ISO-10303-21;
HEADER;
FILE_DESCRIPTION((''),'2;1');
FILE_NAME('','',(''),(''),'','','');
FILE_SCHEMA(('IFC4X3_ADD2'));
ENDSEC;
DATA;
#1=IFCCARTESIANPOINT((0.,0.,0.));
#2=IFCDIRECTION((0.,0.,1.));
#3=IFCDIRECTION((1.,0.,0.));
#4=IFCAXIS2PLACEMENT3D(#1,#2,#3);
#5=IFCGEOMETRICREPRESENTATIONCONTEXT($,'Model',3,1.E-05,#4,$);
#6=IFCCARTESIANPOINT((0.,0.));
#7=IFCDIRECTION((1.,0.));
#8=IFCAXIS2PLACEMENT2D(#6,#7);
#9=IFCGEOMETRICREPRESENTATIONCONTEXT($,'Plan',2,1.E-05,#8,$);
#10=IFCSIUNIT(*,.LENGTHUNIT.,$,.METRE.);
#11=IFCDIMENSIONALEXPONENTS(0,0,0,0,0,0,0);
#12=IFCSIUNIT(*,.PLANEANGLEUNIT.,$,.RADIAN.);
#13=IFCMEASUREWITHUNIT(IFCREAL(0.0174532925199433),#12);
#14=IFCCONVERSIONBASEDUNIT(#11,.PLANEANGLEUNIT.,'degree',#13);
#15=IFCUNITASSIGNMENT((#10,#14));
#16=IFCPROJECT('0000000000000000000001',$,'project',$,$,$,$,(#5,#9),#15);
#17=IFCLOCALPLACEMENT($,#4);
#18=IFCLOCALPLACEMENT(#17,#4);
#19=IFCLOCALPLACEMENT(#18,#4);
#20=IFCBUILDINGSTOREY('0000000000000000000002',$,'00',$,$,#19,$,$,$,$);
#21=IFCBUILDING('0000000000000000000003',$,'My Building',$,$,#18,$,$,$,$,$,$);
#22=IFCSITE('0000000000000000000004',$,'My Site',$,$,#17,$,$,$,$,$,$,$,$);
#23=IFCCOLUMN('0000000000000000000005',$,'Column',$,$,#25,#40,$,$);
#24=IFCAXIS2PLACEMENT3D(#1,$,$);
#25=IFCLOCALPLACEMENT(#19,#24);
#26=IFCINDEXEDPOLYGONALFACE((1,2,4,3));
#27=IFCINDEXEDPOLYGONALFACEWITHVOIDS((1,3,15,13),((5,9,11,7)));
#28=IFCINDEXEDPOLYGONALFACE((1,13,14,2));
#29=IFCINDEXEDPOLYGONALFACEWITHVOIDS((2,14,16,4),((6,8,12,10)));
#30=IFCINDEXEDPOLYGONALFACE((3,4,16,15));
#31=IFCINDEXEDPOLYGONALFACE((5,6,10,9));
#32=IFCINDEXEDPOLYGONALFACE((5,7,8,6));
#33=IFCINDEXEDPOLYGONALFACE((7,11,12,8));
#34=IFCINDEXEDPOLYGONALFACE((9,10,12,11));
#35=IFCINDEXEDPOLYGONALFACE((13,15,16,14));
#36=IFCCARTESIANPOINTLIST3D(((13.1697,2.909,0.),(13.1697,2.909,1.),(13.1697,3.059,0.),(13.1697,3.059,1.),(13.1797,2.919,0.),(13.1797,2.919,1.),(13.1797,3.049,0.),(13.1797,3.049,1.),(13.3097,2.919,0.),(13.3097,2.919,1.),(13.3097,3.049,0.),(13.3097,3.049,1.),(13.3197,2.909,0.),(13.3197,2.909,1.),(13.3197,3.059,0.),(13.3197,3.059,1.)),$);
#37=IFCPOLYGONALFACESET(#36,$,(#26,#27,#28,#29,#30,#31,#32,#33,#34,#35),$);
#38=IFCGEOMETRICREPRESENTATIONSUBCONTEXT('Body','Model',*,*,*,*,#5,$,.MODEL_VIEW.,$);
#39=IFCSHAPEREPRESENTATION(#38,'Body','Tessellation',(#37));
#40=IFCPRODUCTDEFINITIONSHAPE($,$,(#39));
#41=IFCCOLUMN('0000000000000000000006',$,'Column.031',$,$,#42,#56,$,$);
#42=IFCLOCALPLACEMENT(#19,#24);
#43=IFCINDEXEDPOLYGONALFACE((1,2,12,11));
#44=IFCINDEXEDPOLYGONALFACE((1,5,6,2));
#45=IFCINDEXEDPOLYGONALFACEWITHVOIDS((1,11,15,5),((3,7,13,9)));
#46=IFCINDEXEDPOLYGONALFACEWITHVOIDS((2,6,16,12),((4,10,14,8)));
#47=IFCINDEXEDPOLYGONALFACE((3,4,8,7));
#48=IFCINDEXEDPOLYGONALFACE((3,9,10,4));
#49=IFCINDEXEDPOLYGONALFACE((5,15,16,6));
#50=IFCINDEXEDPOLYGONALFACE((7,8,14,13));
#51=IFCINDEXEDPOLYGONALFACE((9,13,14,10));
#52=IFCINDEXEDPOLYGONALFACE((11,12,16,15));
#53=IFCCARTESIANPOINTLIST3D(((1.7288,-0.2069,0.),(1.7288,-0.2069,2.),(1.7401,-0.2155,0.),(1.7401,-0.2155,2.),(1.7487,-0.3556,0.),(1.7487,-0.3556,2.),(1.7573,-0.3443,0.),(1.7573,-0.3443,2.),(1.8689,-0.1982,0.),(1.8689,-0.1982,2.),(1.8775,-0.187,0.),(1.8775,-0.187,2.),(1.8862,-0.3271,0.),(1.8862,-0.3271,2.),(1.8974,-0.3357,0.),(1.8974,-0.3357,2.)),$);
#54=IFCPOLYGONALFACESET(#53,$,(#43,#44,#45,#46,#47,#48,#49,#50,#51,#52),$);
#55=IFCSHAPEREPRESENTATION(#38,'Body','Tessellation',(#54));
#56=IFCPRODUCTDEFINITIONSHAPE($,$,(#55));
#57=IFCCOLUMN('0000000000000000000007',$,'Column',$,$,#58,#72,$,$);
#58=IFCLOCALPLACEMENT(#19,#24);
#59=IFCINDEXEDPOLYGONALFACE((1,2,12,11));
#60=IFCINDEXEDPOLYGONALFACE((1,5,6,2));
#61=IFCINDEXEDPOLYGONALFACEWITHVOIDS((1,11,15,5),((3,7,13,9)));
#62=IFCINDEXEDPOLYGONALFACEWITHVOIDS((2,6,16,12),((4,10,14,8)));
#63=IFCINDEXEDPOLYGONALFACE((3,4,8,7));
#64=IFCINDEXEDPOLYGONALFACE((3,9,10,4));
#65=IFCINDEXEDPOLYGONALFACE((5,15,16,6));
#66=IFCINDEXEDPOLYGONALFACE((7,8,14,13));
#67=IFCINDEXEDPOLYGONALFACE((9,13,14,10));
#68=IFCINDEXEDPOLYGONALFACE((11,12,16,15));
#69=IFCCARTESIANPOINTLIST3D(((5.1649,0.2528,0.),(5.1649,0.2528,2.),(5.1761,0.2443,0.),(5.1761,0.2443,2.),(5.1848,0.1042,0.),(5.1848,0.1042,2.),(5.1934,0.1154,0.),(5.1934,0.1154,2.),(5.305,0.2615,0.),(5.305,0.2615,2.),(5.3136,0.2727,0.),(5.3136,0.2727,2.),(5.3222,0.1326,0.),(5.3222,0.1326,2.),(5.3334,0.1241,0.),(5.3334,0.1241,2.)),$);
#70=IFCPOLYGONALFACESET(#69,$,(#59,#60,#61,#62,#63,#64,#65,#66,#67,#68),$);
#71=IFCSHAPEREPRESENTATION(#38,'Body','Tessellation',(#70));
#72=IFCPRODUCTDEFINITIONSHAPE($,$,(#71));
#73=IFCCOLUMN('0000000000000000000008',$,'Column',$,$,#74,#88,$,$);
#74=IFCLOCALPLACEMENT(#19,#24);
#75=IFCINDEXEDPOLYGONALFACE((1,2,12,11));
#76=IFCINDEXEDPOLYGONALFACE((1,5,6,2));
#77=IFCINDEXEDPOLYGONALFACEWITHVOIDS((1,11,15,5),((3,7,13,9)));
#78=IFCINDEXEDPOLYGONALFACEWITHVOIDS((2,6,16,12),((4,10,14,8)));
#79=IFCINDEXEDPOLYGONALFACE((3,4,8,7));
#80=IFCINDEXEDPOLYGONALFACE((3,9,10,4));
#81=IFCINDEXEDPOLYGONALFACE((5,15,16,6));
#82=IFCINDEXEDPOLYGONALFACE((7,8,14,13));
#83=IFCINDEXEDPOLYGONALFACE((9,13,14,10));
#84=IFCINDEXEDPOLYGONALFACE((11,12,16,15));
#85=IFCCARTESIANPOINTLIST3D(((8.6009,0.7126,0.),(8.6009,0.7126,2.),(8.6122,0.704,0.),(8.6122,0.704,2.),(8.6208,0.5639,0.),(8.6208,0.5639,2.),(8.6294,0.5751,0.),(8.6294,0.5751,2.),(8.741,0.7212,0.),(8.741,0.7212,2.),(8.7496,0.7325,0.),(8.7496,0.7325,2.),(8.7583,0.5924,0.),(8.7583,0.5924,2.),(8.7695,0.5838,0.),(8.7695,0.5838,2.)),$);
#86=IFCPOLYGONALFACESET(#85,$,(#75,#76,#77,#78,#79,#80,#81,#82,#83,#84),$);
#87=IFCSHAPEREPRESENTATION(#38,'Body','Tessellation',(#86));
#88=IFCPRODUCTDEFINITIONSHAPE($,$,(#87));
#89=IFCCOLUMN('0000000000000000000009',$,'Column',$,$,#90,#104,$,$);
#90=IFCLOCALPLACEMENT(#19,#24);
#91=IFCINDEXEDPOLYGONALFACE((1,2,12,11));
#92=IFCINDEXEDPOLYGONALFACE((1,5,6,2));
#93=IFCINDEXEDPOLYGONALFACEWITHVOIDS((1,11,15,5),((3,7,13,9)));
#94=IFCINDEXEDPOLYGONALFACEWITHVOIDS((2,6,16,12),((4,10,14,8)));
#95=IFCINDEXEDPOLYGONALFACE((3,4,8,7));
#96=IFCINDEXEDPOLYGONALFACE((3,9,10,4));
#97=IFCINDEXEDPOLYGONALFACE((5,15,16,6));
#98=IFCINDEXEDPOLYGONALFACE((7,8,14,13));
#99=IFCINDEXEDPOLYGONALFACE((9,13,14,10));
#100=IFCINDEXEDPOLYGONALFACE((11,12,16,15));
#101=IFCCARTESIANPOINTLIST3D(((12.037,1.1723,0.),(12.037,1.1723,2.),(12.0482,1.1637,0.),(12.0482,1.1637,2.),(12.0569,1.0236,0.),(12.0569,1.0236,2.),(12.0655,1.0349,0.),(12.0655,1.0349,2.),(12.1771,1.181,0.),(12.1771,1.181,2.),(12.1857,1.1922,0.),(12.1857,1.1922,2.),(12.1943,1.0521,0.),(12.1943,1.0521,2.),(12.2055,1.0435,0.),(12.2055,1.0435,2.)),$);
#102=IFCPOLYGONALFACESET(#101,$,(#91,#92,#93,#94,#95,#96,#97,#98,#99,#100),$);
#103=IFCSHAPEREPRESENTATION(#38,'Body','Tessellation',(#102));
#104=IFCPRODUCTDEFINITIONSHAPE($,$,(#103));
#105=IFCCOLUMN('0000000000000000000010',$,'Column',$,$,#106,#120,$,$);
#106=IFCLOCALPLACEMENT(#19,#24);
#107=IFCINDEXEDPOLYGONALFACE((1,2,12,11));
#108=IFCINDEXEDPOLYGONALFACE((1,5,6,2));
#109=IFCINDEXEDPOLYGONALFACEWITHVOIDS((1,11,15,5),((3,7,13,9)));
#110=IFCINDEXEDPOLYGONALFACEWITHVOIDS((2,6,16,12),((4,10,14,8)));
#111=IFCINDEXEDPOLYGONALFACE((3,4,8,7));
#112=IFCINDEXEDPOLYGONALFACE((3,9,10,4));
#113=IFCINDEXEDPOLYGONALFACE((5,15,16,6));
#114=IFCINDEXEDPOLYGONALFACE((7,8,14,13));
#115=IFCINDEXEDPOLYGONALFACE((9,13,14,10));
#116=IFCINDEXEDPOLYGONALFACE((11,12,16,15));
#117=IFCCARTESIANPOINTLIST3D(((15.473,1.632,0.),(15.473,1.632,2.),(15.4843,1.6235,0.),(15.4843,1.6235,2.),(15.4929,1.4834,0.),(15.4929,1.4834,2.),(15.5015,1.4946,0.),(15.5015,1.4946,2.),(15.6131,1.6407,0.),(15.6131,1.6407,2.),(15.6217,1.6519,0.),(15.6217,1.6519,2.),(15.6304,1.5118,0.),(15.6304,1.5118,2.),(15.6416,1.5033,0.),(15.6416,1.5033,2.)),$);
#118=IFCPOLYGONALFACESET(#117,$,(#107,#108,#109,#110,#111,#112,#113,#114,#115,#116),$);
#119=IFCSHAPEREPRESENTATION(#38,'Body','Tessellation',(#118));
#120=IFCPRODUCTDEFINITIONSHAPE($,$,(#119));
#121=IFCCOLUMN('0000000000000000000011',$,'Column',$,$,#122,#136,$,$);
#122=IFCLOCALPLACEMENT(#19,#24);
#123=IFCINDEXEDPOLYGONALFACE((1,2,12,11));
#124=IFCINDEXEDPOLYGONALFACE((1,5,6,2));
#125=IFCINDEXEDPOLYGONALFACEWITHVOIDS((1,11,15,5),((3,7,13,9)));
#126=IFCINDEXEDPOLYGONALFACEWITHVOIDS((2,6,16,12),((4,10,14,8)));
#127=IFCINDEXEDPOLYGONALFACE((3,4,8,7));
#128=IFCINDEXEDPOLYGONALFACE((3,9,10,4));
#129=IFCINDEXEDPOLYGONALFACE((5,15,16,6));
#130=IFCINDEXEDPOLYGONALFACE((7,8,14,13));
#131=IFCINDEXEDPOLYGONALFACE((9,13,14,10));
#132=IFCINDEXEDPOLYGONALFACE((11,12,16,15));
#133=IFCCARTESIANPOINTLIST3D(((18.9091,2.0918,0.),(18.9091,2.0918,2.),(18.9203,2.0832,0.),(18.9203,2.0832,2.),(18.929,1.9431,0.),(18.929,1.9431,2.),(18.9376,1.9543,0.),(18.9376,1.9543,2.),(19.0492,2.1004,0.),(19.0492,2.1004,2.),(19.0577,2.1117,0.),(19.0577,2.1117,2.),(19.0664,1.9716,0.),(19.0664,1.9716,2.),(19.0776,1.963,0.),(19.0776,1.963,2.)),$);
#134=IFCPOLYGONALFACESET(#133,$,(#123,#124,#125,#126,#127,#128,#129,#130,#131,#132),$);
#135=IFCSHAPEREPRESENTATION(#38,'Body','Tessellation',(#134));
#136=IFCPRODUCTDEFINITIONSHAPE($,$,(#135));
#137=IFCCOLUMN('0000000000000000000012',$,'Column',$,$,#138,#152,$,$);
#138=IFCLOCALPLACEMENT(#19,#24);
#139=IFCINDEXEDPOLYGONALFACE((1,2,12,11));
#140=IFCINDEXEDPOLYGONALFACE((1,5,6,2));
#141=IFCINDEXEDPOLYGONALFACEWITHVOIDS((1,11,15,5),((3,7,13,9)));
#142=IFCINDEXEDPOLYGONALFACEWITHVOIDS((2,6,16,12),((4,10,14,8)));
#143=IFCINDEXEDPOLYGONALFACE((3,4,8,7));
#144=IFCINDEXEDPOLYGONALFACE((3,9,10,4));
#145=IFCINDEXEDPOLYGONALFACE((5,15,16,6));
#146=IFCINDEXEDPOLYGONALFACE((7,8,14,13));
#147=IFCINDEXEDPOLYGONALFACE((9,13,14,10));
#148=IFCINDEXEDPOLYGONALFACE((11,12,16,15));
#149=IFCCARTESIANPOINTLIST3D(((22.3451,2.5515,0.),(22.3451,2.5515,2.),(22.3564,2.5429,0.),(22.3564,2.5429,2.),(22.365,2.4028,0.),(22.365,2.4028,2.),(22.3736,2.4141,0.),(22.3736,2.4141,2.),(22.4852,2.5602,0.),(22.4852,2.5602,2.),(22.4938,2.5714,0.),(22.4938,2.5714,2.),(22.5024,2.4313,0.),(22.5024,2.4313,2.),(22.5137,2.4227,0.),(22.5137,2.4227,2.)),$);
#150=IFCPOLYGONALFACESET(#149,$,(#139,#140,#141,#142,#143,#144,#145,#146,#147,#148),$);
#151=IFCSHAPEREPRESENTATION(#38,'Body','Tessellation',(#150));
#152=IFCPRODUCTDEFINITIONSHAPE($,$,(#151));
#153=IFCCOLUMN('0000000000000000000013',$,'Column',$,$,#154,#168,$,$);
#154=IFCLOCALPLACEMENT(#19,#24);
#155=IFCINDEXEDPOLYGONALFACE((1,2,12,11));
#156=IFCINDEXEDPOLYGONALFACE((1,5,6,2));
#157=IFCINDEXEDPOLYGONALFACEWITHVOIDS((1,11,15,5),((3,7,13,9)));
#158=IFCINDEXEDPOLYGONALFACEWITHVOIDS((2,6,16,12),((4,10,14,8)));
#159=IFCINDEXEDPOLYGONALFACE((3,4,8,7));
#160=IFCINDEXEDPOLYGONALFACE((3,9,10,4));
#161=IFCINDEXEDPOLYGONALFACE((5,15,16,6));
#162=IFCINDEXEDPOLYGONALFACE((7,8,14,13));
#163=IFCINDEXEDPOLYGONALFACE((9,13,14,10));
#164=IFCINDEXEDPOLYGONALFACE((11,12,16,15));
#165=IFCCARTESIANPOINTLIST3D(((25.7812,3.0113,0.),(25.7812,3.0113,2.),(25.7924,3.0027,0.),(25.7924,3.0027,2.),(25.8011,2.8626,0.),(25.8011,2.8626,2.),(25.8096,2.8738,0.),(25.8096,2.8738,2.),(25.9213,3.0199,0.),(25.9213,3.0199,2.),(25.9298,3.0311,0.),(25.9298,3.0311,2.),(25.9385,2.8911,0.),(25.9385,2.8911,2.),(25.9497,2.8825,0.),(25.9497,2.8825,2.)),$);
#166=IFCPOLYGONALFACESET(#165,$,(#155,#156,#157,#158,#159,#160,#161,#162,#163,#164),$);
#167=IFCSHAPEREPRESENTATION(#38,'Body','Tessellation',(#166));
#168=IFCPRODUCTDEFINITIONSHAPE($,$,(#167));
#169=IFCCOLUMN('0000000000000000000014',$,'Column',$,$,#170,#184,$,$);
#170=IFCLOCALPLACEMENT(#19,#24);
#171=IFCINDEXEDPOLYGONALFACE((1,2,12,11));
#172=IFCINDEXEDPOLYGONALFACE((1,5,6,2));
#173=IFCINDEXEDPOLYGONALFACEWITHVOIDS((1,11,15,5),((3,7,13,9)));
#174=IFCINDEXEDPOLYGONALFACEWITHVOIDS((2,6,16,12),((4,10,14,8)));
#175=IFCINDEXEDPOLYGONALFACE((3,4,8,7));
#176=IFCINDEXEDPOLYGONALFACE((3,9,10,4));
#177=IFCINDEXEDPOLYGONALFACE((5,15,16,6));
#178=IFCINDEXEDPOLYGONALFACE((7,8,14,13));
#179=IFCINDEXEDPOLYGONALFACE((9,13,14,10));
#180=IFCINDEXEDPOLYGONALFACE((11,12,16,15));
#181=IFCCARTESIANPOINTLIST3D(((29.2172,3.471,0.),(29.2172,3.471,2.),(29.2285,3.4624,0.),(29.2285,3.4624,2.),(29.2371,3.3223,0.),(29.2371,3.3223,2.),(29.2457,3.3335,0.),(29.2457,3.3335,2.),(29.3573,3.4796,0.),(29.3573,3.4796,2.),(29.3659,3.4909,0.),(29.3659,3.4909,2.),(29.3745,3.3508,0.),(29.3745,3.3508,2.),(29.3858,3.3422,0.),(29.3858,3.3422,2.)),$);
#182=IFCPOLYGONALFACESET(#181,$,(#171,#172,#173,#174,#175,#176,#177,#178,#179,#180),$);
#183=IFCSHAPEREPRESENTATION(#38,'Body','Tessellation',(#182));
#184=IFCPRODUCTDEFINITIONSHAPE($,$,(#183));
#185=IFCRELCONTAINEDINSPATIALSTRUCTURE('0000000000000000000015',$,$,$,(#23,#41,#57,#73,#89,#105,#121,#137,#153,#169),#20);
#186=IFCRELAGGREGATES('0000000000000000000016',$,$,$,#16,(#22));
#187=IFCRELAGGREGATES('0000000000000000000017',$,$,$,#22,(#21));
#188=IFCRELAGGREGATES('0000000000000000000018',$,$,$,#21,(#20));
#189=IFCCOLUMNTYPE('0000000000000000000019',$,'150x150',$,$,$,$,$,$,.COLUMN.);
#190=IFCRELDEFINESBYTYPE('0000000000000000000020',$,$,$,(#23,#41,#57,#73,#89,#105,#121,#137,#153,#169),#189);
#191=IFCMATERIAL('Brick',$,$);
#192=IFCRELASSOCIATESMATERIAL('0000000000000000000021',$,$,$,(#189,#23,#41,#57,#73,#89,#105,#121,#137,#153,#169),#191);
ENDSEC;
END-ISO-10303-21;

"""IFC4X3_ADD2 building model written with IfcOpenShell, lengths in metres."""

from ifc_helpers import new_model, entity, si_unit, converted_unit, frame, origin_with_axes, origin_2d_with_axis, place, context, subcontext, project, spatial, hollow_rectangle, extrude, shape, material, material_profile, profile_set, profile_usage, type_object, element, save


model = new_model("IFC4X3_ADD2")

# Units and contexts
model_context = context("Model", 3, precision=1e-05, world=origin_with_axes())
plan_context = context("Plan", 2, precision=1e-05, world=origin_2d_with_axis())
body_context_1 = subcontext(model_context, "Body", "Model", "MODEL_VIEW")
body_context_2 = subcontext(plan_context, "Body", "Plan", "PLAN_VIEW")
ifc_project = project(units=[si_unit("LENGTHUNIT", "METRE"), converted_unit("PLANEANGLEUNIT", "degree", entity("IfcReal", 0.0174532925199433), si_unit("PLANEANGLEUNIT", "RADIAN"), dimensions=[0, 0, 0, 0, 0, 0, 0])], contexts=[model_context, plan_context])

# Site, building, storey
site_placement = place(None, origin_with_axes())
site = spatial("IfcSite", under=ifc_project, at=site_placement, Name="My Site")
building_placement = place(site_placement, origin_with_axes())
building = spatial("IfcBuilding", under=site, at=building_placement, Name="My Building")
storey_placement = place(building_placement, origin_with_axes())
storey = spatial("IfcBuildingStorey", under=building, at=storey_placement, Name="00")

# Columns
ifc_material_1 = material(Name="Brick")
ifc_material_profile = material_profile(ifc_material_1, hollow_rectangle(XDim=0.15, YDim=0.15, WallThickness=0.01))
ifc_profile_set = profile_set([ifc_material_profile])
ifc_profile_usage_1 = profile_usage(ifc_profile_set, cardinal=5)
column_type = type_object("IfcColumnType", Name="150x150", PredefinedType="COLUMN", material=ifc_profile_set)
column_1_placement = place(storey_placement, frame((13.2447, 2.984, 0.0), z_axis=(0.0, 0.0, 1.0), x_axis=(1.0, 0.0, 0.0)))
element("IfcColumn", 1, at=column_1_placement, inside=storey, type_object=column_type, material=ifc_profile_usage_1, Name="Column", shapes=[
    shape(body_context_1, "Body", "SweptSolid", [extrude(hollow_rectangle(XDim=0.15, YDim=0.15, WallThickness=0.01), origin_with_axes(), (0.0, 0.0, 1.0), 1.0)]),
    shape(body_context_2, "Body", "Annotation2D", [entity("IfcGeometricCurveSet", [entity("IfcIndexedPolyCurve", entity("IfcCartesianPointList2D", [[-0.065, -0.065], [-0.065, 0.065], [0.065, 0.065], [0.065, -0.065]]), [entity("IfcLineIndex", [1, 2, 3, 4, 1])]), entity("IfcIndexedPolyCurve", entity("IfcCartesianPointList2D", [[0.075, -0.075], [-0.075, -0.075], [-0.075, 0.075], [0.075, 0.075]]), [entity("IfcLineIndex", [1, 2, 3, 4, 1])])])]),
])
ifc_profile_usage_2 = profile_usage(ifc_profile_set, cardinal=5)
column_2_placement = place(storey_placement, frame((1.8131, -0.2713, 0.0), z_axis=(0.0, 0.0, 1.0), x_axis=(0.991168, 0.132616, 0.0)))
element("IfcColumn", 2, at=column_2_placement, inside=storey, type_object=column_type, material=ifc_profile_usage_2, Name="Column.031", context=body_context_1, shape_type="SweptSolid", body=[
    extrude(hollow_rectangle(XDim=0.15, YDim=0.15, WallThickness=0.01), origin_with_axes(), (0.0, 0.0, 1.0), 2.0),
])
ifc_profile_usage_3 = profile_usage(ifc_profile_set, cardinal=5)
column_3_placement = place(storey_placement, frame((5.2492, 0.1884, 0.0), z_axis=(0.0, 0.0, 1.0), x_axis=(0.991168, 0.132616, 0.0)))
element("IfcColumn", 3, at=column_3_placement, inside=storey, type_object=column_type, material=ifc_profile_usage_3, Name="Column", context=body_context_1, shape_type="SweptSolid", body=[
    extrude(hollow_rectangle(XDim=0.15, YDim=0.15, WallThickness=0.01), origin_with_axes(), (0.0, 0.0, 1.0), 2.0),
])
ifc_profile_usage_4 = profile_usage(ifc_profile_set, cardinal=5)
column_4_placement = place(storey_placement, frame((8.6852, 0.6482, 0.0), z_axis=(0.0, 0.0, 1.0), x_axis=(0.991168, 0.132616, 0.0)))
element("IfcColumn", 4, at=column_4_placement, inside=storey, type_object=column_type, material=ifc_profile_usage_4, Name="Column", context=body_context_1, shape_type="SweptSolid", body=[
    extrude(hollow_rectangle(XDim=0.15, YDim=0.15, WallThickness=0.01), origin_with_axes(), (0.0, 0.0, 1.0), 2.0),
])
ifc_profile_usage_5 = profile_usage(ifc_profile_set, cardinal=5)
column_5_placement = place(storey_placement, frame((12.1213, 1.1079, 0.0), z_axis=(0.0, 0.0, 1.0), x_axis=(0.991168, 0.132616, 0.0)))
element("IfcColumn", 5, at=column_5_placement, inside=storey, type_object=column_type, material=ifc_profile_usage_5, Name="Column", context=body_context_1, shape_type="SweptSolid", body=[
    extrude(hollow_rectangle(XDim=0.15, YDim=0.15, WallThickness=0.01), origin_with_axes(), (0.0, 0.0, 1.0), 2.0),
])
ifc_profile_usage_6 = profile_usage(ifc_profile_set, cardinal=5)
column_6_placement = place(storey_placement, frame((15.5573, 1.5677, 0.0), z_axis=(0.0, 0.0, 1.0), x_axis=(0.991168, 0.132616, 0.0)))
element("IfcColumn", 6, at=column_6_placement, inside=storey, type_object=column_type, material=ifc_profile_usage_6, Name="Column", context=body_context_1, shape_type="SweptSolid", body=[
    extrude(hollow_rectangle(XDim=0.15, YDim=0.15, WallThickness=0.01), origin_with_axes(), (0.0, 0.0, 1.0), 2.0),
])
ifc_profile_usage_7 = profile_usage(ifc_profile_set, cardinal=5)
column_7_placement = place(storey_placement, frame((18.9934, 2.0274, 0.0), z_axis=(0.0, 0.0, 1.0), x_axis=(0.991168, 0.132616, 0.0)))
element("IfcColumn", 7, at=column_7_placement, inside=storey, type_object=column_type, material=ifc_profile_usage_7, Name="Column", context=body_context_1, shape_type="SweptSolid", body=[
    extrude(hollow_rectangle(XDim=0.15, YDim=0.15, WallThickness=0.01), origin_with_axes(), (0.0, 0.0, 1.0), 2.0),
])
ifc_profile_usage_8 = profile_usage(ifc_profile_set, cardinal=5)
column_8_placement = place(storey_placement, frame((22.4294, 2.4871, 0.0), z_axis=(0.0, 0.0, 1.0), x_axis=(0.991168, 0.132616, 0.0)))
element("IfcColumn", 8, at=column_8_placement, inside=storey, type_object=column_type, material=ifc_profile_usage_8, Name="Column", context=body_context_1, shape_type="SweptSolid", body=[
    extrude(hollow_rectangle(XDim=0.15, YDim=0.15, WallThickness=0.01), origin_with_axes(), (0.0, 0.0, 1.0), 2.0),
])
ifc_profile_usage_9 = profile_usage(ifc_profile_set, cardinal=5)
column_9_placement = place(storey_placement, frame((25.8655, 2.9469, 0.0), z_axis=(0.0, 0.0, 1.0), x_axis=(0.991168, 0.132616, 0.0)))
element("IfcColumn", 9, at=column_9_placement, inside=storey, type_object=column_type, material=ifc_profile_usage_9, Name="Column", shapes=[
    shape(body_context_1, "Body", "SweptSolid", [extrude(hollow_rectangle(XDim=0.15, YDim=0.15, WallThickness=0.01), origin_with_axes(), (0.0, 0.0, 1.0), 2.0)]),
    shape(body_context_2, "Body", "Annotation2D", [entity("IfcGeometricCurveSet", [entity("IfcIndexedPolyCurve", entity("IfcCartesianPointList2D", [[0.075, -0.075], [0.075, 0.075], [-0.075, 0.075], [-0.075, -0.075]]), [entity("IfcLineIndex", [1, 2, 3, 4, 1])]), entity("IfcIndexedPolyCurve", entity("IfcCartesianPointList2D", [[-0.065, -0.065], [0.065, -0.065], [0.065, 0.065], [-0.065, 0.065]]), [entity("IfcLineIndex", [1, 2, 3, 4, 1])])])]),
])
ifc_profile_usage_10 = profile_usage(ifc_profile_set, cardinal=5)
column_10_placement = place(storey_placement, frame((29.3015, 3.4066, 0.0), z_axis=(0.0, 0.0, 1.0), x_axis=(0.991168, 0.132616, 0.0)))
element("IfcColumn", 10, at=column_10_placement, inside=storey, type_object=column_type, material=ifc_profile_usage_10, Name="Column", shapes=[
    shape(body_context_1, "Body", "SweptSolid", [extrude(hollow_rectangle(XDim=0.15, YDim=0.15, WallThickness=0.01), origin_with_axes(), (0.0, 0.0, 1.0), 2.0)]),
    shape(body_context_2, "Body", "Annotation2D", [entity("IfcGeometricCurveSet", [entity("IfcIndexedPolyCurve", entity("IfcCartesianPointList2D", [[-0.065, -0.065], [-0.065, 0.065], [0.065, 0.065], [0.065, -0.065]]), [entity("IfcLineIndex", [1, 2, 3, 4, 1])]), entity("IfcIndexedPolyCurve", entity("IfcCartesianPointList2D", [[0.075, -0.075], [0.075, 0.075], [-0.075, 0.075], [-0.075, -0.075]]), [entity("IfcLineIndex", [1, 2, 3, 4, 1])])])]),
])

save(model, "model.ifc")
